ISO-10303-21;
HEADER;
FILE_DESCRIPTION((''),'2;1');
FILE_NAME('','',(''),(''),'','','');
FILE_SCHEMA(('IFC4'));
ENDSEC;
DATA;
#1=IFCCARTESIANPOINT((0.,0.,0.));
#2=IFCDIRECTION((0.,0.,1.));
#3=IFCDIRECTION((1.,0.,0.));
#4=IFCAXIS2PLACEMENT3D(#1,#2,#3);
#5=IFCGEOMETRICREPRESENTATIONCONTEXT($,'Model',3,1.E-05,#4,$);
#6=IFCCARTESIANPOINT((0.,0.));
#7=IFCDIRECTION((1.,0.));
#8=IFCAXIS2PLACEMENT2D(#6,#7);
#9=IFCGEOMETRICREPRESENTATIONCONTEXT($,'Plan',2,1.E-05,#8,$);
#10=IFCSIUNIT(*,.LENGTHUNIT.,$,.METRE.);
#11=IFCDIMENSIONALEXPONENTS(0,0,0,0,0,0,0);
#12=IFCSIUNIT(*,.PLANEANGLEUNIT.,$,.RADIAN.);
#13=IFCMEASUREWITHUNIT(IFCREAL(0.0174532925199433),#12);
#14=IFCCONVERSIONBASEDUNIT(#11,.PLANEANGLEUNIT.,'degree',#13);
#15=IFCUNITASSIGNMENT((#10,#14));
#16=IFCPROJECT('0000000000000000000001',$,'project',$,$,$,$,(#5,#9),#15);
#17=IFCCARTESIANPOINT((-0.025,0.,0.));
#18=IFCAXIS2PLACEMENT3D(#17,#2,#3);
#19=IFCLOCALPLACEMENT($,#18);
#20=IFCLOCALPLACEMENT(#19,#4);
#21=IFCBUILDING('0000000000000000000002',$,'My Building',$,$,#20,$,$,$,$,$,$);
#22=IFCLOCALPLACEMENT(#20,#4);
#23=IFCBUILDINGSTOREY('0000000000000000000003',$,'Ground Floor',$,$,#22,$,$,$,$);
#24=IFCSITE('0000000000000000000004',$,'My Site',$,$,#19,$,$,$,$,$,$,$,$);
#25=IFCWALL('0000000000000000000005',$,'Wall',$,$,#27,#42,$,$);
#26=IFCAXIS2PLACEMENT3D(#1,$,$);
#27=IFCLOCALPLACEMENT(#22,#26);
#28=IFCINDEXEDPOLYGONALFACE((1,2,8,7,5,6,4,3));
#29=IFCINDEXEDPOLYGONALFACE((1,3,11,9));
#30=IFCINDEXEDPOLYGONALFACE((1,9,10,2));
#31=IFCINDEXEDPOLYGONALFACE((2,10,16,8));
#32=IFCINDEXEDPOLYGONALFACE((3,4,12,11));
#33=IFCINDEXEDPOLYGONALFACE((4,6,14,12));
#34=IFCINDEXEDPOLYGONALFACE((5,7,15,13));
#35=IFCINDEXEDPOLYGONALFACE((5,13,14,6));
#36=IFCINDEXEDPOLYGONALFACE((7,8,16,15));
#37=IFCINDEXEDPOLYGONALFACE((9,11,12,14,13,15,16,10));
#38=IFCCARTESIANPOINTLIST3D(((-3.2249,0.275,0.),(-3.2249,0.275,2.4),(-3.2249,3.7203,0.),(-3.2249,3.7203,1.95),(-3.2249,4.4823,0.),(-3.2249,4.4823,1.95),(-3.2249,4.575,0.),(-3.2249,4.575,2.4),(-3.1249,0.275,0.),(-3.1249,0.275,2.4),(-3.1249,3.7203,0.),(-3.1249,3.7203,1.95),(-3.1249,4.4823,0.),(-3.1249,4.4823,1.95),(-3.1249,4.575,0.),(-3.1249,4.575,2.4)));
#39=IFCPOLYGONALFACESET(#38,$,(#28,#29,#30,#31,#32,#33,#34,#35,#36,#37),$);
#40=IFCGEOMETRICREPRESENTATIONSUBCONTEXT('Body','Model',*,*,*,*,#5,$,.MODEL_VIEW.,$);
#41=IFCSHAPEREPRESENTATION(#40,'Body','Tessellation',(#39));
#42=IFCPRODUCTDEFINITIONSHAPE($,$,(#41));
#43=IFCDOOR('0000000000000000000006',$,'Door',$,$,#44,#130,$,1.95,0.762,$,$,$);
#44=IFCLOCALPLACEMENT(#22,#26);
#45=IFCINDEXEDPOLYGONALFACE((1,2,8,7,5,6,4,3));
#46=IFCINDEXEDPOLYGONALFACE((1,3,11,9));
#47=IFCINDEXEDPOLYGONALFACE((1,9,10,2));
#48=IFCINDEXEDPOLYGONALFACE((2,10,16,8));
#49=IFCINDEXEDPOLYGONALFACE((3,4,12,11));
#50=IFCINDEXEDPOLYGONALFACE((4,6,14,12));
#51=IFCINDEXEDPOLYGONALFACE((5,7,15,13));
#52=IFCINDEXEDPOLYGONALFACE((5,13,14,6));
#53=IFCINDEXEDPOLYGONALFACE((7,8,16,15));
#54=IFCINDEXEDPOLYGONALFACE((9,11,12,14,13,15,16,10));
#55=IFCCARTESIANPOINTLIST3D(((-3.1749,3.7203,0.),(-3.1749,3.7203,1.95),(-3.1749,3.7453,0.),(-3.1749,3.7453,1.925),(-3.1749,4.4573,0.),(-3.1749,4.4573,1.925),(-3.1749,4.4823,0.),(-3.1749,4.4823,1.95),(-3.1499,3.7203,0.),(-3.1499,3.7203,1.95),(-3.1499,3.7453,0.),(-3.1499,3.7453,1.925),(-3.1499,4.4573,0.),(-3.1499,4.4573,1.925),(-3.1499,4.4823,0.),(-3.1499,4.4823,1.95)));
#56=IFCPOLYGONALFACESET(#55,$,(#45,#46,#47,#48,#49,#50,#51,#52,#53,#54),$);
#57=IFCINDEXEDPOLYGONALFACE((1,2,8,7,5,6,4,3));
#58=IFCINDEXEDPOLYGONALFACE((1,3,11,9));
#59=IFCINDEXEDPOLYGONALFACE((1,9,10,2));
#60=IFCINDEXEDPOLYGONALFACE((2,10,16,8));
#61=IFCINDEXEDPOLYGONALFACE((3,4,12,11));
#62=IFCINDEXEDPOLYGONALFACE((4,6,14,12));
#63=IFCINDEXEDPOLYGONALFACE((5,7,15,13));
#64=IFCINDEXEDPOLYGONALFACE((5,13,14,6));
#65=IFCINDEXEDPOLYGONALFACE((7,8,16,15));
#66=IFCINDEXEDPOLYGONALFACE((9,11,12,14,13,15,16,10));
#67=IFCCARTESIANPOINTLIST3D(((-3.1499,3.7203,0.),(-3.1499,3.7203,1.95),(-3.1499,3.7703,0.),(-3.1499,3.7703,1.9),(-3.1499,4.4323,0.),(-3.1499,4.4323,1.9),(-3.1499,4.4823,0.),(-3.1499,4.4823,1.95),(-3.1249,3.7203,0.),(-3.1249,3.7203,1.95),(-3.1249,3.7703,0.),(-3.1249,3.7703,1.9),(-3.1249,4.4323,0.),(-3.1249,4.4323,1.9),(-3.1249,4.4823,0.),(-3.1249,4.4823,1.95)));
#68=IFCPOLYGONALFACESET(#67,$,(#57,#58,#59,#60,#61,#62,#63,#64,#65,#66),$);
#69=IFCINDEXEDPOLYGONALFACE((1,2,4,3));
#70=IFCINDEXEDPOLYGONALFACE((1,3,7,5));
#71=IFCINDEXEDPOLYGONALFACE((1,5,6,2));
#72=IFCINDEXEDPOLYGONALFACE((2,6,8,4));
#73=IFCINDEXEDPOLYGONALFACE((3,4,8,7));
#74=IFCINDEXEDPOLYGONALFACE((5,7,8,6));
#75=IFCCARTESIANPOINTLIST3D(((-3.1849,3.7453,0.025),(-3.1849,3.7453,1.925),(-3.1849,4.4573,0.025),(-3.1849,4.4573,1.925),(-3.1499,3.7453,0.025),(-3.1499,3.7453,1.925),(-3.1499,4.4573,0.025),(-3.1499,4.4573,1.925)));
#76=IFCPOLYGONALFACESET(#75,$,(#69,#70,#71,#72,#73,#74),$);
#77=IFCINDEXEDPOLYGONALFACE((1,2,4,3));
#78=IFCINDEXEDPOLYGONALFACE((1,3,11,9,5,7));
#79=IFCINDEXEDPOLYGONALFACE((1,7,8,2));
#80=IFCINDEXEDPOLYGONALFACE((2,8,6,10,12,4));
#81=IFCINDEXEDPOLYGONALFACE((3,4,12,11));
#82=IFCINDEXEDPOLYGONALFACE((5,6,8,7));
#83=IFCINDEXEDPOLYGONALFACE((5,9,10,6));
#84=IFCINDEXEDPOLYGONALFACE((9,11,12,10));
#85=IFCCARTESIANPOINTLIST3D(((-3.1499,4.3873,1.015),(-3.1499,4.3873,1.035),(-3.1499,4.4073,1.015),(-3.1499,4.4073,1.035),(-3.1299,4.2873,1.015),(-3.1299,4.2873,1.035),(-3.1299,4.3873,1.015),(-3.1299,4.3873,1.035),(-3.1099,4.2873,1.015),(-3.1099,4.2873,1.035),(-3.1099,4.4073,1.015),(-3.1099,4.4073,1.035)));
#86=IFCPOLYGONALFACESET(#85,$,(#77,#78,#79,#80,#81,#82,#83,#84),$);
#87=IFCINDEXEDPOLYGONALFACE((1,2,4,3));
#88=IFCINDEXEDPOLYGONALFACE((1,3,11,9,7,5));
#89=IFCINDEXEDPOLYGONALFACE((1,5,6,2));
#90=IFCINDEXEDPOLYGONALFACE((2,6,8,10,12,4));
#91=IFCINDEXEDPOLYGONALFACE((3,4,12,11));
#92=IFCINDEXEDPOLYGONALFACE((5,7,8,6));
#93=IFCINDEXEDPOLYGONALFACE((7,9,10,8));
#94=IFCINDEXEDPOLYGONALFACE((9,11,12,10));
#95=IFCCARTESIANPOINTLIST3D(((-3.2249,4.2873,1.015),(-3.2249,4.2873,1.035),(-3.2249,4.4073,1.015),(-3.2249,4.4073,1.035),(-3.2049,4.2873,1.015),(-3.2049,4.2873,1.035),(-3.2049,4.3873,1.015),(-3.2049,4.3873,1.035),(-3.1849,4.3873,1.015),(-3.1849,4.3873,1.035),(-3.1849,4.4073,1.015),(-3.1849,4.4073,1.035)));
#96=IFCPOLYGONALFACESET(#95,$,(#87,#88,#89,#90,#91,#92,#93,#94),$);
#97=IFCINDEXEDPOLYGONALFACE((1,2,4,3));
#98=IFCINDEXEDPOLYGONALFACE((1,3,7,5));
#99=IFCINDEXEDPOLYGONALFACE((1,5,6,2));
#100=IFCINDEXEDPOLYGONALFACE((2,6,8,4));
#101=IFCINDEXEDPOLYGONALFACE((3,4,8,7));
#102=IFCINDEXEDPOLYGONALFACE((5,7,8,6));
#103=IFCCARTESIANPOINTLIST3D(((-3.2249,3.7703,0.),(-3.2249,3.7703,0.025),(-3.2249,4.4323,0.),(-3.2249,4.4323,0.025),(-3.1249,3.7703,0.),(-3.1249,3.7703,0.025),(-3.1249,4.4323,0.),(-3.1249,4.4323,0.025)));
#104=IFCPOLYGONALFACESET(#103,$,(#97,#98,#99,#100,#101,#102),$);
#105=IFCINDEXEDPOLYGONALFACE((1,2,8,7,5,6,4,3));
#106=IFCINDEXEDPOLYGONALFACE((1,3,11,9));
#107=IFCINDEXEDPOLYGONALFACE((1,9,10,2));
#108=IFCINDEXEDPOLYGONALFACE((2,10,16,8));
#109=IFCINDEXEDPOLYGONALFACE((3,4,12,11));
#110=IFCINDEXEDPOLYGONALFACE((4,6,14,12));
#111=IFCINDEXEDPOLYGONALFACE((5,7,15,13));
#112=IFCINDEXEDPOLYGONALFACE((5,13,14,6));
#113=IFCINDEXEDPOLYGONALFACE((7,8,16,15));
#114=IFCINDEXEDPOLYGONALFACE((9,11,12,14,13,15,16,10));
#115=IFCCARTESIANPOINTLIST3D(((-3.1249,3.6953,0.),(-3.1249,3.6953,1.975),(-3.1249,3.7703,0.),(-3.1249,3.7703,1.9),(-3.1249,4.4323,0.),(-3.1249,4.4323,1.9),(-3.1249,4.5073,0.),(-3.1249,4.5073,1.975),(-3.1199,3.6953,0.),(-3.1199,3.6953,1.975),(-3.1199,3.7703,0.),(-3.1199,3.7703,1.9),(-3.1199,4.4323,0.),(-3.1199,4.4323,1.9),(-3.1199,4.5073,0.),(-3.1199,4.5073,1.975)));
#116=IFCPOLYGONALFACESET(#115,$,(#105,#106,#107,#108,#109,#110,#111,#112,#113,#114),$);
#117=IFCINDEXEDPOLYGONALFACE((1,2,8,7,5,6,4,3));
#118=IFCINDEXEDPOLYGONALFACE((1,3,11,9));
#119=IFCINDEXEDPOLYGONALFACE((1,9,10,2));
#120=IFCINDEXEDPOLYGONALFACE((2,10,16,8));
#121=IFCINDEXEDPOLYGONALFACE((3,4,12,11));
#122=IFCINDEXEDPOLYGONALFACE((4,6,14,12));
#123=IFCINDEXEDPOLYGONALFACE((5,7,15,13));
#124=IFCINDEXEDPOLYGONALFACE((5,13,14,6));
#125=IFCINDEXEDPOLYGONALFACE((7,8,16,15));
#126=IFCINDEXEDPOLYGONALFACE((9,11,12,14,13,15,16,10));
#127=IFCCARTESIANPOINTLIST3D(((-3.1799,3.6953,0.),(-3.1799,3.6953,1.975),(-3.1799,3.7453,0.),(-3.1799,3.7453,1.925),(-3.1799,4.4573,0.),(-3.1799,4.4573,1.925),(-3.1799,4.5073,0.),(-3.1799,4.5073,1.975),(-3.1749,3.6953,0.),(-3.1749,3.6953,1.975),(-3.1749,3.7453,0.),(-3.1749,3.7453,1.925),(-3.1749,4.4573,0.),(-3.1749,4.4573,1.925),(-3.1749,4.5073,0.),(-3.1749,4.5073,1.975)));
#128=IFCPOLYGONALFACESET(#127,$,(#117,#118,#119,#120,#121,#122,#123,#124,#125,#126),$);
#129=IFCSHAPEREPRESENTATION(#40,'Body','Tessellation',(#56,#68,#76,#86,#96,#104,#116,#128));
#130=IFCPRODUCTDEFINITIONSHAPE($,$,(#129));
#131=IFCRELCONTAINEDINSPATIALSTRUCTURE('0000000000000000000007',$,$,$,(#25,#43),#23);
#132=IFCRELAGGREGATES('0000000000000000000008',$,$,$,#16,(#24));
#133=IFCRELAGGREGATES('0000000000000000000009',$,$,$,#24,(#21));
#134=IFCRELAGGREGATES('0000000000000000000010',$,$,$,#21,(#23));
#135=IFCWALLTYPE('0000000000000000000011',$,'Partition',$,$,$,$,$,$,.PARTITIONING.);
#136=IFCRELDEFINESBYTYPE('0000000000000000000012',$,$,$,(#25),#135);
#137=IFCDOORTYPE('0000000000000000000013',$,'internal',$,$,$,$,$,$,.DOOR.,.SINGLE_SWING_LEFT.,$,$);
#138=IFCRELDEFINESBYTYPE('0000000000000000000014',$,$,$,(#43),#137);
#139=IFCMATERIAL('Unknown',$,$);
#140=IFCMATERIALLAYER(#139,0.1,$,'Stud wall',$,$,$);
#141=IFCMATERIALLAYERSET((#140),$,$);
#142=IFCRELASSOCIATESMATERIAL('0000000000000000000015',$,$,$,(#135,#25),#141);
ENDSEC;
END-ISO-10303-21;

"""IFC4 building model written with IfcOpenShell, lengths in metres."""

from ifc_helpers import new_model, entity, si_unit, converted_unit, frame, origin_with_axes, origin_2d_with_axis, place, context, subcontext, project, spatial, line, indexed_curve, outline, extrude, shape, source, transform, mapped, material, layer, layer_set, layer_usage, type_object, type_shapes, element, fill, save


model = new_model("IFC4")

# Units and contexts
model_context = context("Model", 3, precision=1e-05, world=origin_with_axes())
plan_context = context("Plan", 2, precision=1e-05, world=origin_2d_with_axis())
body_context_1 = subcontext(model_context, "Body", "Model", "MODEL_VIEW")
body_context_2 = subcontext(plan_context, "Body", "Plan", "PLAN_VIEW")
ifc_project = project(units=[si_unit("LENGTHUNIT", "METRE"), converted_unit("PLANEANGLEUNIT", "degree", entity("IfcReal", 0.0174532925199433), si_unit("PLANEANGLEUNIT", "RADIAN"), dimensions=[0, 0, 0, 0, 0, 0, 0])], contexts=[model_context, plan_context])

# Site, building, storey
site_placement = place(None, frame((-0.025, 0.0, 0.0), z_axis=(0.0, 0.0, 1.0), x_axis=(1.0, 0.0, 0.0)))
site = spatial("IfcSite", under=ifc_project, at=site_placement, Name="My Site")
building_placement = place(site_placement, origin_with_axes())
building = spatial("IfcBuilding", under=site, at=building_placement, Name="My Building")
storey_placement = place(building_placement, frame((0.0, 0.0, 0.0), z_axis=(0.0, 0.0, 1.0), x_axis=(1.0, 0.0, 0.0)))
storey = spatial("IfcBuildingStorey", under=building, at=storey_placement, Name="Ground Floor")

# Shared definitions
ifc_material = material(Name="Unknown")
shared_shape_1 = source(origin_with_axes(), body_context_1, "Body", "SweptSolid", [
    extrude(outline(indexed_curve([(0.0, 0.0), (0.762, 0.0), (0.762, 1.95), (0.0, 1.95)], segments=[line(1, 2, 3, 4, 1)])), frame((0.0, -0.1, 0.0), z_axis=(0.0, -1.0, 0.0), x_axis=(1.0, 0.0, 0.0)), (0.0, 0.0, -1.0), 0.3),
])
door_type = type_object("IfcDoorType", Name="internal", OperationType="SINGLE_SWING_LEFT", PredefinedType="DOOR")
shared_shape_2 = source(origin_with_axes(), body_context_1, "Body", "SweptSolid", [
    extrude(outline(indexed_curve([(0.0, 0.0), (0.0, 1.95), (0.762, 1.95), (0.762, 0.0), (0.737, 0.0), (0.737, 1.925), (0.025, 1.925), (0.025, 0.0)], segments=[line(1, 2, 3, 4, 5, 6, 7, 8, 1)])), frame((0.0, 0.025, 0.0), z_axis=(0.0, -1.0, 0.0), x_axis=(1.0, 0.0, 0.0)), (0.0, 0.0, -1.0), 0.025),
    extrude(outline(indexed_curve([(0.0, 0.0), (0.0, 1.95), (0.762, 1.95), (0.762, 0.0), (0.712, 0.0), (0.712, 1.9), (0.05, 1.9), (0.05, 0.0)], segments=[line(1, 2, 3, 4, 5, 6, 7, 8, 1)])), frame((0.0, 0.0, 0.0), z_axis=(0.0, -1.0, 0.0), x_axis=(1.0, 0.0, 0.0)), (0.0, 0.0, -1.0), 0.025),
    extrude(outline(indexed_curve([(0.0, 0.0), (0.712, 0.0), (0.712, 0.035), (0.0, 0.035)], segments=[line(1, 2, 3, 4, 1)])), frame((0.025, 0.025, 0.025), z_axis=(0.0, 0.0, 1.0), x_axis=(1.0, 0.0, 0.0)), (0.0, 0.0, 1.0), 1.9),
    extrude(outline(indexed_curve([(0.0, 0.0), (0.0, -0.04), (-0.12, -0.04), (-0.12, -0.02), (-0.02, -0.02), (-0.02, 0.0)], segments=[line(1, 2, 3, 4, 5, 6, 1)])), frame((0.687, 0.025, 1.015), z_axis=(0.0, 0.0, 1.0), x_axis=(1.0, 0.0, 0.0)), (0.0, 0.0, 1.0), 0.02),
    extrude(outline(indexed_curve([(0.0, 0.0), (0.0, 0.04), (-0.12, 0.04), (-0.12, 0.02), (-0.02, 0.02), (-0.02, 0.0)], segments=[line(1, 2, 3, 4, 5, 6, 1)])), frame((0.687, 0.06, 1.015), z_axis=(0.0, 0.0, 1.0), x_axis=(1.0, 0.0, 0.0)), (0.0, 0.0, 1.0), 0.02),
    extrude(outline(indexed_curve([(0.0, 0.0), (0.662, 0.0), (0.662, 0.1), (0.0, 0.1)], segments=[line(1, 2, 3, 4, 1)])), frame((0.05, 0.0, 0.0), z_axis=(0.0, 0.0, 1.0), x_axis=(1.0, 0.0, 0.0)), (0.0, 0.0, 1.0), 0.025),
    extrude(outline(indexed_curve([(0.0, 0.0), (0.0, 1.975), (0.812, 1.975), (0.812, 0.0), (0.737, 0.0), (0.737, 1.9), (0.075, 1.9), (0.075, 0.0)], segments=[line(1, 2, 3, 4, 5, 6, 7, 8, 1)])), frame((-0.025, -0.005, 0.0), z_axis=(0.0, -1.0, 0.0), x_axis=(1.0, 0.0, 0.0)), (0.0, 0.0, -1.0), 0.005),
    extrude(outline(indexed_curve([(0.0, 0.0), (0.0, 1.975), (0.812, 1.975), (0.812, 0.0), (0.762, 0.0), (0.762, 1.925), (0.05, 1.925), (0.05, 0.0)], segments=[line(1, 2, 3, 4, 5, 6, 7, 8, 1)])), frame((-0.025, 0.05, 0.0), z_axis=(0.0, -1.0, 0.0), x_axis=(1.0, 0.0, 0.0)), (0.0, 0.0, -1.0), 0.005),
])
shared_shape_3 = source(origin_with_axes(), body_context_2, "Body", "Curve2D", [
    entity("IfcIndexedPolyCurve", entity("IfcCartesianPointList2D", [[0.0, 0.0], [0.0, 0.05], [0.025, 0.05], [0.025, 0.025], [0.05, 0.025], [0.05, 0.0]]), [entity("IfcLineIndex", [1, 2, 3, 4, 5, 6, 1])]),
    entity("IfcIndexedPolyCurve", entity("IfcCartesianPointList2D", [[0.762, 0.0], [0.762, 0.05], [0.737, 0.05], [0.737, 0.025], [0.712, 0.025], [0.712, 0.0]]), [entity("IfcLineIndex", [1, 2, 3, 4, 5, 6, 1])]),
    entity("IfcTrimmedCurve", entity("IfcEllipse", entity("IfcAxis2Placement2D", entity("IfcCartesianPoint", [0.06, 0.05]), entity("IfcDirection", [1.0, 0.0])), 0.677, 0.712), [entity("IfcCartesianPoint", [0.737, 0.05])], [entity("IfcCartesianPoint", [0.06, 0.762])], True, "CARTESIAN"),
    entity("IfcIndexedPolyCurve", entity("IfcCartesianPointList2D", [[0.025, 0.05], [0.06, 0.05], [0.06, 0.762], [0.025, 0.762]]), [entity("IfcLineIndex", [1, 2, 3, 4, 1])]),
])
type_shapes(door_type, [shared_shape_2, shared_shape_3])

# Wall, opening, door
ifc_layer_1 = layer(ifc_material, 0.1, Name="Stud wall")
ifc_layer_set_1 = layer_set([ifc_layer_1])
ifc_layer_usage_1 = layer_usage(ifc_layer_set_1, "AXIS2", "POSITIVE", 0.0)
wall_type_1 = type_object("IfcWallType", Name="Partition", PredefinedType="PARTITIONING", material=ifc_layer_set_1)
wall_1_placement = place(storey_placement, frame((-3.1249, 0.275, 0.0), z_axis=(0.0, 0.0, 1.0), x_axis=(0.0, 1.0, 0.0)))
wall_1 = element("IfcWall", 1, at=wall_1_placement, inside=storey, type_object=wall_type_1, material=ifc_layer_usage_1, Name="Wall", context=body_context_1, shape_type="SweptSolid", body=[
    extrude(outline(indexed_curve([(0.0, 0.0), (0.0, 0.1), (4.3, 0.1), (4.3, 0.0), (0.0, 0.0)], self_intersect=False)), origin_with_axes(), (0.0, 0.0, 1.0), 2.4),
])
opening_1_placement = place(wall_1_placement, frame((3.4453, 0.0, 0.0), z_axis=(0.0, 0.0, 1.0), x_axis=(1.0, 0.0, 0.0)))
opening_1 = element("IfcOpeningElement", 2, at=opening_1_placement, cuts=wall_1, PredefinedType="OPENING", context=body_context_1, shape_type="MappedRepresentation", body=[
    mapped(shared_shape_1, transform((0.0, 0.0, 0.0), x_axis=(1.0, 0.0, 0.0), y_axis=(0.0, 1.0, 0.0), z_axis=(0.0, 0.0, 1.0), scale=1.0)),
])
door_1_placement = place(opening_1_placement, frame((0.0, 0.0, 0.0), z_axis=(0.0, 0.0, 1.0), x_axis=(1.0, 0.0, 0.0)))
door_1 = element("IfcDoor", 3, at=door_1_placement, inside=storey, type_object=door_type, Name="Door", OverallHeight=1.95, OverallWidth=0.762, shapes=[
    shape(body_context_1, "Body", "MappedRepresentation", [mapped(shared_shape_2, transform((0.0, 0.0, 0.0), x_axis=(1.0, 0.0, 0.0), y_axis=(0.0, 1.0, 0.0), z_axis=(0.0, 0.0, 1.0), scale=1.0))]),
    shape(body_context_2, "Body", "MappedRepresentation", [mapped(shared_shape_3, transform((0.0, 0.0, 0.0), x_axis=(1.0, 0.0, 0.0), y_axis=(0.0, 1.0, 0.0), z_axis=(0.0, 0.0, 1.0), scale=1.0))]),
])
fill(opening_1, door_1)

save(model, "model.ifc")
